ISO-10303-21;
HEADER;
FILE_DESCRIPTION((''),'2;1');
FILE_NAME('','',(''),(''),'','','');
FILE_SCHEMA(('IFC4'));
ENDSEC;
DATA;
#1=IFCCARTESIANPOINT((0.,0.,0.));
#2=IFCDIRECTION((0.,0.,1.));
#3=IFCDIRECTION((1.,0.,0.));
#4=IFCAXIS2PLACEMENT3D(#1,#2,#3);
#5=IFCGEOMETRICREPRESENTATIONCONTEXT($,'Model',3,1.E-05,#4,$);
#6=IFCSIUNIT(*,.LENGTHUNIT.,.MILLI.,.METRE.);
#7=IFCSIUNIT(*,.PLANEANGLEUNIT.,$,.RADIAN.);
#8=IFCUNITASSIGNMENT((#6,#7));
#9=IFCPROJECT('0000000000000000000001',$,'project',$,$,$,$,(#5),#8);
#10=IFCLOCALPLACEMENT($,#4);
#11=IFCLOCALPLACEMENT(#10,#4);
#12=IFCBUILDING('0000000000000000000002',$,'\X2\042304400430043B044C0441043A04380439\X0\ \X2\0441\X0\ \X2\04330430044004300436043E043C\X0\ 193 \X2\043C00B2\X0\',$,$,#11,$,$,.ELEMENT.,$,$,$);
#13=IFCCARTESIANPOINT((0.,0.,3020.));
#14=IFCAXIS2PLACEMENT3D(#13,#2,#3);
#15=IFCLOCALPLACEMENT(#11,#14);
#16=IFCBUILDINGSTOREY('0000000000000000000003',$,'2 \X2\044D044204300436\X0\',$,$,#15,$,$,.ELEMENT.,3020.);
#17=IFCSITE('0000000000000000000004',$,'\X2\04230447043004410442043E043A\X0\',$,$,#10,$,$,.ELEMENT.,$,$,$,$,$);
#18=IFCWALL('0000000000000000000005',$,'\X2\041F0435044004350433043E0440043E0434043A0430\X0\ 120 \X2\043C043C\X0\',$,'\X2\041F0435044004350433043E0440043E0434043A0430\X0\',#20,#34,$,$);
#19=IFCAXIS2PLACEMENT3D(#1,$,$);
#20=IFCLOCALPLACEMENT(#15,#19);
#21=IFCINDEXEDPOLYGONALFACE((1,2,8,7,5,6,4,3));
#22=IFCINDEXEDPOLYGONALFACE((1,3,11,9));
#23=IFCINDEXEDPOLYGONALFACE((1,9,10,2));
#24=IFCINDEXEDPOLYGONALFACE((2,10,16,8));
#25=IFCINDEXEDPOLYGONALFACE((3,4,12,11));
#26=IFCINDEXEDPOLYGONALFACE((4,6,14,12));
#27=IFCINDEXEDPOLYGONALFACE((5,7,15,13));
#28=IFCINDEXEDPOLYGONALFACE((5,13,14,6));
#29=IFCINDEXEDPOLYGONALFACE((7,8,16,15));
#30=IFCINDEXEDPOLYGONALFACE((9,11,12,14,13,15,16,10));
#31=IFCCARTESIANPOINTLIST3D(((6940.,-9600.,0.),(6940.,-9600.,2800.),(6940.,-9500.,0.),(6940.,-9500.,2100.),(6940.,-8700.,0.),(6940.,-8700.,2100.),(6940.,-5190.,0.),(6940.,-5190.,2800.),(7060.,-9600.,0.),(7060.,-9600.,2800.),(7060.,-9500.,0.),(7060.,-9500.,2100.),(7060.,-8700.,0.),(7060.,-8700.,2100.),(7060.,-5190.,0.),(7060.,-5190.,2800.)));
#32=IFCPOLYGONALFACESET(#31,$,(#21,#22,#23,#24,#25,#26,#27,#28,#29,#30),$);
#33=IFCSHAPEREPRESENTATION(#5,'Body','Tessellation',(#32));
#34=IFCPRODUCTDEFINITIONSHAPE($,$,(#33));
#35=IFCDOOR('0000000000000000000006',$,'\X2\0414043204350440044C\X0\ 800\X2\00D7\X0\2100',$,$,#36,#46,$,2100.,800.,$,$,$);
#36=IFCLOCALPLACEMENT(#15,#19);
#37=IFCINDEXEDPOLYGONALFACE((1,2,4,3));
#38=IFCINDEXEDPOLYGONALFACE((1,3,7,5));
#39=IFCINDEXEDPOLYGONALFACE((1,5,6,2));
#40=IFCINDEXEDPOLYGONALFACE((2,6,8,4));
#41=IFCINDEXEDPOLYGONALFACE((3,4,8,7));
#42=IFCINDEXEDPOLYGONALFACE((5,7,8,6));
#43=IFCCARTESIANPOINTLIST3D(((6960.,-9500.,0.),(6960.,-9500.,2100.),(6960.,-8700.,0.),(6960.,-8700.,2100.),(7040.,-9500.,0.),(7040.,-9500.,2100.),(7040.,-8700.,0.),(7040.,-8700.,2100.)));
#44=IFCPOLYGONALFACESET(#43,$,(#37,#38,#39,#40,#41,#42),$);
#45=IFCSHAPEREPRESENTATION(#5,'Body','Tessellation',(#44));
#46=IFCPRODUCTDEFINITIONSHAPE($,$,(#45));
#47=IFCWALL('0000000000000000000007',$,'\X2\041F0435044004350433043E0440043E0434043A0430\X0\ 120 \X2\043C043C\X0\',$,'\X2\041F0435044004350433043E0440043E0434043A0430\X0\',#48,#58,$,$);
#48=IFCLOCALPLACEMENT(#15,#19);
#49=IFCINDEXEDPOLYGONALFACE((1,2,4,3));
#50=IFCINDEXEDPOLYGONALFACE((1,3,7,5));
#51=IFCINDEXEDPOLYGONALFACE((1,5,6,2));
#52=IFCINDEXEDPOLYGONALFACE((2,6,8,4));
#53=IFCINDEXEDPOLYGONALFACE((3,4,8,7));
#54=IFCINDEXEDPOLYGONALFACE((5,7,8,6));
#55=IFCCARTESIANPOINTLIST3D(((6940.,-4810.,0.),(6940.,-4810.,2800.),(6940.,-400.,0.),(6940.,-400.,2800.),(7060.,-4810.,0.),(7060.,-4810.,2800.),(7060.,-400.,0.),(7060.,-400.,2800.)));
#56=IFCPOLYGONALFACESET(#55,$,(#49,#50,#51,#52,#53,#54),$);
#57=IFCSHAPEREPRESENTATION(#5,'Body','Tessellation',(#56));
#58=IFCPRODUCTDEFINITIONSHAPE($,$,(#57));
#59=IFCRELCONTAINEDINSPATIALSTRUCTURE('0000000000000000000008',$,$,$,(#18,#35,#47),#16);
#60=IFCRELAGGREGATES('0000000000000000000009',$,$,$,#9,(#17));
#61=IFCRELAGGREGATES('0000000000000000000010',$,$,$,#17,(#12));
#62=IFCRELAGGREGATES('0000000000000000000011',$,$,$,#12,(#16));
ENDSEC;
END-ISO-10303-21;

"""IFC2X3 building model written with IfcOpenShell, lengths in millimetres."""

from ifc_helpers import new_model, si_unit, frame, frame_2d, origin, origin_with_axes, place, context, project, spatial, rectangle, extrude, element, fill, save


model = new_model("IFC2X3")

# Units and contexts
model_context = context("Model", 3, precision=1e-05, world=origin_with_axes())
ifc_project = project(units=[si_unit("LENGTHUNIT", "METRE", prefix="MILLI"), si_unit("PLANEANGLEUNIT", "RADIAN")], contexts=[model_context])

# Site, building, storey
site_placement = place(None, origin_with_axes())
site = spatial("IfcSite", under=ifc_project, at=site_placement, Name="Участок", CompositionType="ELEMENT")
building_placement = place(site_placement, origin_with_axes())
building = spatial("IfcBuilding", under=site, at=building_placement, Name="Уральский с гаражом 193 м²", CompositionType="ELEMENT")
storey_placement = place(building_placement, frame((0.0, 0.0, 3020.0), z_axis=(0.0, 0.0, 1.0), x_axis=(1.0, 0.0, 0.0)))
storey = spatial("IfcBuildingStorey", under=building, at=storey_placement, Name="2 этаж", CompositionType="ELEMENT", Elevation=3020.0)

# Wall, opening, door
wall_1_placement = place(storey_placement, origin_with_axes())
wall_1 = element("IfcWall", 1, at=wall_1_placement, inside=storey, Name="Перегородка 120 мм", ObjectType="Перегородка", context=model_context, shape_type="SweptSolid", body=[
    extrude(rectangle(XDim=120.0, YDim=4410.0, at=frame_2d((7000.0, -7395.0))), origin(), (0.0, 0.0, 1.0), 2800.0),
])
opening_1_placement = place(storey_placement, origin_with_axes())
opening_1 = element("IfcOpeningElement", 2, at=opening_1_placement, cuts=wall_1, ObjectType="Opening", context=model_context, shape_type="SweptSolid", body=[
    extrude(rectangle(XDim=140.0, YDim=800.0, at=frame_2d((7000.0, -9100.0))), origin(), (0.0, 0.0, 1.0), 2100.0),
])
door_1_placement = place(storey_placement, origin_with_axes())
door_1 = element("IfcDoor", 3, at=door_1_placement, inside=storey, Name="Дверь 800×2100", OverallHeight=2100.0, OverallWidth=800.0, context=model_context, shape_type="SweptSolid", body=[
    extrude(rectangle(XDim=80.0, YDim=800.0, at=frame_2d((7000.0, -9100.0))), origin(), (0.0, 0.0, 1.0), 2100.0),
])
fill(opening_1, door_1)

# Wall
wall_2_placement = place(storey_placement, origin_with_axes())
element("IfcWall", 4, at=wall_2_placement, inside=storey, Name="Перегородка 120 мм", ObjectType="Перегородка", context=model_context, shape_type="SweptSolid", body=[
    extrude(rectangle(XDim=120.0, YDim=4410.0, at=frame_2d((7000.0, -2605.0))), origin(), (0.0, 0.0, 1.0), 2800.0),
])

save(model, "model.ifc")
